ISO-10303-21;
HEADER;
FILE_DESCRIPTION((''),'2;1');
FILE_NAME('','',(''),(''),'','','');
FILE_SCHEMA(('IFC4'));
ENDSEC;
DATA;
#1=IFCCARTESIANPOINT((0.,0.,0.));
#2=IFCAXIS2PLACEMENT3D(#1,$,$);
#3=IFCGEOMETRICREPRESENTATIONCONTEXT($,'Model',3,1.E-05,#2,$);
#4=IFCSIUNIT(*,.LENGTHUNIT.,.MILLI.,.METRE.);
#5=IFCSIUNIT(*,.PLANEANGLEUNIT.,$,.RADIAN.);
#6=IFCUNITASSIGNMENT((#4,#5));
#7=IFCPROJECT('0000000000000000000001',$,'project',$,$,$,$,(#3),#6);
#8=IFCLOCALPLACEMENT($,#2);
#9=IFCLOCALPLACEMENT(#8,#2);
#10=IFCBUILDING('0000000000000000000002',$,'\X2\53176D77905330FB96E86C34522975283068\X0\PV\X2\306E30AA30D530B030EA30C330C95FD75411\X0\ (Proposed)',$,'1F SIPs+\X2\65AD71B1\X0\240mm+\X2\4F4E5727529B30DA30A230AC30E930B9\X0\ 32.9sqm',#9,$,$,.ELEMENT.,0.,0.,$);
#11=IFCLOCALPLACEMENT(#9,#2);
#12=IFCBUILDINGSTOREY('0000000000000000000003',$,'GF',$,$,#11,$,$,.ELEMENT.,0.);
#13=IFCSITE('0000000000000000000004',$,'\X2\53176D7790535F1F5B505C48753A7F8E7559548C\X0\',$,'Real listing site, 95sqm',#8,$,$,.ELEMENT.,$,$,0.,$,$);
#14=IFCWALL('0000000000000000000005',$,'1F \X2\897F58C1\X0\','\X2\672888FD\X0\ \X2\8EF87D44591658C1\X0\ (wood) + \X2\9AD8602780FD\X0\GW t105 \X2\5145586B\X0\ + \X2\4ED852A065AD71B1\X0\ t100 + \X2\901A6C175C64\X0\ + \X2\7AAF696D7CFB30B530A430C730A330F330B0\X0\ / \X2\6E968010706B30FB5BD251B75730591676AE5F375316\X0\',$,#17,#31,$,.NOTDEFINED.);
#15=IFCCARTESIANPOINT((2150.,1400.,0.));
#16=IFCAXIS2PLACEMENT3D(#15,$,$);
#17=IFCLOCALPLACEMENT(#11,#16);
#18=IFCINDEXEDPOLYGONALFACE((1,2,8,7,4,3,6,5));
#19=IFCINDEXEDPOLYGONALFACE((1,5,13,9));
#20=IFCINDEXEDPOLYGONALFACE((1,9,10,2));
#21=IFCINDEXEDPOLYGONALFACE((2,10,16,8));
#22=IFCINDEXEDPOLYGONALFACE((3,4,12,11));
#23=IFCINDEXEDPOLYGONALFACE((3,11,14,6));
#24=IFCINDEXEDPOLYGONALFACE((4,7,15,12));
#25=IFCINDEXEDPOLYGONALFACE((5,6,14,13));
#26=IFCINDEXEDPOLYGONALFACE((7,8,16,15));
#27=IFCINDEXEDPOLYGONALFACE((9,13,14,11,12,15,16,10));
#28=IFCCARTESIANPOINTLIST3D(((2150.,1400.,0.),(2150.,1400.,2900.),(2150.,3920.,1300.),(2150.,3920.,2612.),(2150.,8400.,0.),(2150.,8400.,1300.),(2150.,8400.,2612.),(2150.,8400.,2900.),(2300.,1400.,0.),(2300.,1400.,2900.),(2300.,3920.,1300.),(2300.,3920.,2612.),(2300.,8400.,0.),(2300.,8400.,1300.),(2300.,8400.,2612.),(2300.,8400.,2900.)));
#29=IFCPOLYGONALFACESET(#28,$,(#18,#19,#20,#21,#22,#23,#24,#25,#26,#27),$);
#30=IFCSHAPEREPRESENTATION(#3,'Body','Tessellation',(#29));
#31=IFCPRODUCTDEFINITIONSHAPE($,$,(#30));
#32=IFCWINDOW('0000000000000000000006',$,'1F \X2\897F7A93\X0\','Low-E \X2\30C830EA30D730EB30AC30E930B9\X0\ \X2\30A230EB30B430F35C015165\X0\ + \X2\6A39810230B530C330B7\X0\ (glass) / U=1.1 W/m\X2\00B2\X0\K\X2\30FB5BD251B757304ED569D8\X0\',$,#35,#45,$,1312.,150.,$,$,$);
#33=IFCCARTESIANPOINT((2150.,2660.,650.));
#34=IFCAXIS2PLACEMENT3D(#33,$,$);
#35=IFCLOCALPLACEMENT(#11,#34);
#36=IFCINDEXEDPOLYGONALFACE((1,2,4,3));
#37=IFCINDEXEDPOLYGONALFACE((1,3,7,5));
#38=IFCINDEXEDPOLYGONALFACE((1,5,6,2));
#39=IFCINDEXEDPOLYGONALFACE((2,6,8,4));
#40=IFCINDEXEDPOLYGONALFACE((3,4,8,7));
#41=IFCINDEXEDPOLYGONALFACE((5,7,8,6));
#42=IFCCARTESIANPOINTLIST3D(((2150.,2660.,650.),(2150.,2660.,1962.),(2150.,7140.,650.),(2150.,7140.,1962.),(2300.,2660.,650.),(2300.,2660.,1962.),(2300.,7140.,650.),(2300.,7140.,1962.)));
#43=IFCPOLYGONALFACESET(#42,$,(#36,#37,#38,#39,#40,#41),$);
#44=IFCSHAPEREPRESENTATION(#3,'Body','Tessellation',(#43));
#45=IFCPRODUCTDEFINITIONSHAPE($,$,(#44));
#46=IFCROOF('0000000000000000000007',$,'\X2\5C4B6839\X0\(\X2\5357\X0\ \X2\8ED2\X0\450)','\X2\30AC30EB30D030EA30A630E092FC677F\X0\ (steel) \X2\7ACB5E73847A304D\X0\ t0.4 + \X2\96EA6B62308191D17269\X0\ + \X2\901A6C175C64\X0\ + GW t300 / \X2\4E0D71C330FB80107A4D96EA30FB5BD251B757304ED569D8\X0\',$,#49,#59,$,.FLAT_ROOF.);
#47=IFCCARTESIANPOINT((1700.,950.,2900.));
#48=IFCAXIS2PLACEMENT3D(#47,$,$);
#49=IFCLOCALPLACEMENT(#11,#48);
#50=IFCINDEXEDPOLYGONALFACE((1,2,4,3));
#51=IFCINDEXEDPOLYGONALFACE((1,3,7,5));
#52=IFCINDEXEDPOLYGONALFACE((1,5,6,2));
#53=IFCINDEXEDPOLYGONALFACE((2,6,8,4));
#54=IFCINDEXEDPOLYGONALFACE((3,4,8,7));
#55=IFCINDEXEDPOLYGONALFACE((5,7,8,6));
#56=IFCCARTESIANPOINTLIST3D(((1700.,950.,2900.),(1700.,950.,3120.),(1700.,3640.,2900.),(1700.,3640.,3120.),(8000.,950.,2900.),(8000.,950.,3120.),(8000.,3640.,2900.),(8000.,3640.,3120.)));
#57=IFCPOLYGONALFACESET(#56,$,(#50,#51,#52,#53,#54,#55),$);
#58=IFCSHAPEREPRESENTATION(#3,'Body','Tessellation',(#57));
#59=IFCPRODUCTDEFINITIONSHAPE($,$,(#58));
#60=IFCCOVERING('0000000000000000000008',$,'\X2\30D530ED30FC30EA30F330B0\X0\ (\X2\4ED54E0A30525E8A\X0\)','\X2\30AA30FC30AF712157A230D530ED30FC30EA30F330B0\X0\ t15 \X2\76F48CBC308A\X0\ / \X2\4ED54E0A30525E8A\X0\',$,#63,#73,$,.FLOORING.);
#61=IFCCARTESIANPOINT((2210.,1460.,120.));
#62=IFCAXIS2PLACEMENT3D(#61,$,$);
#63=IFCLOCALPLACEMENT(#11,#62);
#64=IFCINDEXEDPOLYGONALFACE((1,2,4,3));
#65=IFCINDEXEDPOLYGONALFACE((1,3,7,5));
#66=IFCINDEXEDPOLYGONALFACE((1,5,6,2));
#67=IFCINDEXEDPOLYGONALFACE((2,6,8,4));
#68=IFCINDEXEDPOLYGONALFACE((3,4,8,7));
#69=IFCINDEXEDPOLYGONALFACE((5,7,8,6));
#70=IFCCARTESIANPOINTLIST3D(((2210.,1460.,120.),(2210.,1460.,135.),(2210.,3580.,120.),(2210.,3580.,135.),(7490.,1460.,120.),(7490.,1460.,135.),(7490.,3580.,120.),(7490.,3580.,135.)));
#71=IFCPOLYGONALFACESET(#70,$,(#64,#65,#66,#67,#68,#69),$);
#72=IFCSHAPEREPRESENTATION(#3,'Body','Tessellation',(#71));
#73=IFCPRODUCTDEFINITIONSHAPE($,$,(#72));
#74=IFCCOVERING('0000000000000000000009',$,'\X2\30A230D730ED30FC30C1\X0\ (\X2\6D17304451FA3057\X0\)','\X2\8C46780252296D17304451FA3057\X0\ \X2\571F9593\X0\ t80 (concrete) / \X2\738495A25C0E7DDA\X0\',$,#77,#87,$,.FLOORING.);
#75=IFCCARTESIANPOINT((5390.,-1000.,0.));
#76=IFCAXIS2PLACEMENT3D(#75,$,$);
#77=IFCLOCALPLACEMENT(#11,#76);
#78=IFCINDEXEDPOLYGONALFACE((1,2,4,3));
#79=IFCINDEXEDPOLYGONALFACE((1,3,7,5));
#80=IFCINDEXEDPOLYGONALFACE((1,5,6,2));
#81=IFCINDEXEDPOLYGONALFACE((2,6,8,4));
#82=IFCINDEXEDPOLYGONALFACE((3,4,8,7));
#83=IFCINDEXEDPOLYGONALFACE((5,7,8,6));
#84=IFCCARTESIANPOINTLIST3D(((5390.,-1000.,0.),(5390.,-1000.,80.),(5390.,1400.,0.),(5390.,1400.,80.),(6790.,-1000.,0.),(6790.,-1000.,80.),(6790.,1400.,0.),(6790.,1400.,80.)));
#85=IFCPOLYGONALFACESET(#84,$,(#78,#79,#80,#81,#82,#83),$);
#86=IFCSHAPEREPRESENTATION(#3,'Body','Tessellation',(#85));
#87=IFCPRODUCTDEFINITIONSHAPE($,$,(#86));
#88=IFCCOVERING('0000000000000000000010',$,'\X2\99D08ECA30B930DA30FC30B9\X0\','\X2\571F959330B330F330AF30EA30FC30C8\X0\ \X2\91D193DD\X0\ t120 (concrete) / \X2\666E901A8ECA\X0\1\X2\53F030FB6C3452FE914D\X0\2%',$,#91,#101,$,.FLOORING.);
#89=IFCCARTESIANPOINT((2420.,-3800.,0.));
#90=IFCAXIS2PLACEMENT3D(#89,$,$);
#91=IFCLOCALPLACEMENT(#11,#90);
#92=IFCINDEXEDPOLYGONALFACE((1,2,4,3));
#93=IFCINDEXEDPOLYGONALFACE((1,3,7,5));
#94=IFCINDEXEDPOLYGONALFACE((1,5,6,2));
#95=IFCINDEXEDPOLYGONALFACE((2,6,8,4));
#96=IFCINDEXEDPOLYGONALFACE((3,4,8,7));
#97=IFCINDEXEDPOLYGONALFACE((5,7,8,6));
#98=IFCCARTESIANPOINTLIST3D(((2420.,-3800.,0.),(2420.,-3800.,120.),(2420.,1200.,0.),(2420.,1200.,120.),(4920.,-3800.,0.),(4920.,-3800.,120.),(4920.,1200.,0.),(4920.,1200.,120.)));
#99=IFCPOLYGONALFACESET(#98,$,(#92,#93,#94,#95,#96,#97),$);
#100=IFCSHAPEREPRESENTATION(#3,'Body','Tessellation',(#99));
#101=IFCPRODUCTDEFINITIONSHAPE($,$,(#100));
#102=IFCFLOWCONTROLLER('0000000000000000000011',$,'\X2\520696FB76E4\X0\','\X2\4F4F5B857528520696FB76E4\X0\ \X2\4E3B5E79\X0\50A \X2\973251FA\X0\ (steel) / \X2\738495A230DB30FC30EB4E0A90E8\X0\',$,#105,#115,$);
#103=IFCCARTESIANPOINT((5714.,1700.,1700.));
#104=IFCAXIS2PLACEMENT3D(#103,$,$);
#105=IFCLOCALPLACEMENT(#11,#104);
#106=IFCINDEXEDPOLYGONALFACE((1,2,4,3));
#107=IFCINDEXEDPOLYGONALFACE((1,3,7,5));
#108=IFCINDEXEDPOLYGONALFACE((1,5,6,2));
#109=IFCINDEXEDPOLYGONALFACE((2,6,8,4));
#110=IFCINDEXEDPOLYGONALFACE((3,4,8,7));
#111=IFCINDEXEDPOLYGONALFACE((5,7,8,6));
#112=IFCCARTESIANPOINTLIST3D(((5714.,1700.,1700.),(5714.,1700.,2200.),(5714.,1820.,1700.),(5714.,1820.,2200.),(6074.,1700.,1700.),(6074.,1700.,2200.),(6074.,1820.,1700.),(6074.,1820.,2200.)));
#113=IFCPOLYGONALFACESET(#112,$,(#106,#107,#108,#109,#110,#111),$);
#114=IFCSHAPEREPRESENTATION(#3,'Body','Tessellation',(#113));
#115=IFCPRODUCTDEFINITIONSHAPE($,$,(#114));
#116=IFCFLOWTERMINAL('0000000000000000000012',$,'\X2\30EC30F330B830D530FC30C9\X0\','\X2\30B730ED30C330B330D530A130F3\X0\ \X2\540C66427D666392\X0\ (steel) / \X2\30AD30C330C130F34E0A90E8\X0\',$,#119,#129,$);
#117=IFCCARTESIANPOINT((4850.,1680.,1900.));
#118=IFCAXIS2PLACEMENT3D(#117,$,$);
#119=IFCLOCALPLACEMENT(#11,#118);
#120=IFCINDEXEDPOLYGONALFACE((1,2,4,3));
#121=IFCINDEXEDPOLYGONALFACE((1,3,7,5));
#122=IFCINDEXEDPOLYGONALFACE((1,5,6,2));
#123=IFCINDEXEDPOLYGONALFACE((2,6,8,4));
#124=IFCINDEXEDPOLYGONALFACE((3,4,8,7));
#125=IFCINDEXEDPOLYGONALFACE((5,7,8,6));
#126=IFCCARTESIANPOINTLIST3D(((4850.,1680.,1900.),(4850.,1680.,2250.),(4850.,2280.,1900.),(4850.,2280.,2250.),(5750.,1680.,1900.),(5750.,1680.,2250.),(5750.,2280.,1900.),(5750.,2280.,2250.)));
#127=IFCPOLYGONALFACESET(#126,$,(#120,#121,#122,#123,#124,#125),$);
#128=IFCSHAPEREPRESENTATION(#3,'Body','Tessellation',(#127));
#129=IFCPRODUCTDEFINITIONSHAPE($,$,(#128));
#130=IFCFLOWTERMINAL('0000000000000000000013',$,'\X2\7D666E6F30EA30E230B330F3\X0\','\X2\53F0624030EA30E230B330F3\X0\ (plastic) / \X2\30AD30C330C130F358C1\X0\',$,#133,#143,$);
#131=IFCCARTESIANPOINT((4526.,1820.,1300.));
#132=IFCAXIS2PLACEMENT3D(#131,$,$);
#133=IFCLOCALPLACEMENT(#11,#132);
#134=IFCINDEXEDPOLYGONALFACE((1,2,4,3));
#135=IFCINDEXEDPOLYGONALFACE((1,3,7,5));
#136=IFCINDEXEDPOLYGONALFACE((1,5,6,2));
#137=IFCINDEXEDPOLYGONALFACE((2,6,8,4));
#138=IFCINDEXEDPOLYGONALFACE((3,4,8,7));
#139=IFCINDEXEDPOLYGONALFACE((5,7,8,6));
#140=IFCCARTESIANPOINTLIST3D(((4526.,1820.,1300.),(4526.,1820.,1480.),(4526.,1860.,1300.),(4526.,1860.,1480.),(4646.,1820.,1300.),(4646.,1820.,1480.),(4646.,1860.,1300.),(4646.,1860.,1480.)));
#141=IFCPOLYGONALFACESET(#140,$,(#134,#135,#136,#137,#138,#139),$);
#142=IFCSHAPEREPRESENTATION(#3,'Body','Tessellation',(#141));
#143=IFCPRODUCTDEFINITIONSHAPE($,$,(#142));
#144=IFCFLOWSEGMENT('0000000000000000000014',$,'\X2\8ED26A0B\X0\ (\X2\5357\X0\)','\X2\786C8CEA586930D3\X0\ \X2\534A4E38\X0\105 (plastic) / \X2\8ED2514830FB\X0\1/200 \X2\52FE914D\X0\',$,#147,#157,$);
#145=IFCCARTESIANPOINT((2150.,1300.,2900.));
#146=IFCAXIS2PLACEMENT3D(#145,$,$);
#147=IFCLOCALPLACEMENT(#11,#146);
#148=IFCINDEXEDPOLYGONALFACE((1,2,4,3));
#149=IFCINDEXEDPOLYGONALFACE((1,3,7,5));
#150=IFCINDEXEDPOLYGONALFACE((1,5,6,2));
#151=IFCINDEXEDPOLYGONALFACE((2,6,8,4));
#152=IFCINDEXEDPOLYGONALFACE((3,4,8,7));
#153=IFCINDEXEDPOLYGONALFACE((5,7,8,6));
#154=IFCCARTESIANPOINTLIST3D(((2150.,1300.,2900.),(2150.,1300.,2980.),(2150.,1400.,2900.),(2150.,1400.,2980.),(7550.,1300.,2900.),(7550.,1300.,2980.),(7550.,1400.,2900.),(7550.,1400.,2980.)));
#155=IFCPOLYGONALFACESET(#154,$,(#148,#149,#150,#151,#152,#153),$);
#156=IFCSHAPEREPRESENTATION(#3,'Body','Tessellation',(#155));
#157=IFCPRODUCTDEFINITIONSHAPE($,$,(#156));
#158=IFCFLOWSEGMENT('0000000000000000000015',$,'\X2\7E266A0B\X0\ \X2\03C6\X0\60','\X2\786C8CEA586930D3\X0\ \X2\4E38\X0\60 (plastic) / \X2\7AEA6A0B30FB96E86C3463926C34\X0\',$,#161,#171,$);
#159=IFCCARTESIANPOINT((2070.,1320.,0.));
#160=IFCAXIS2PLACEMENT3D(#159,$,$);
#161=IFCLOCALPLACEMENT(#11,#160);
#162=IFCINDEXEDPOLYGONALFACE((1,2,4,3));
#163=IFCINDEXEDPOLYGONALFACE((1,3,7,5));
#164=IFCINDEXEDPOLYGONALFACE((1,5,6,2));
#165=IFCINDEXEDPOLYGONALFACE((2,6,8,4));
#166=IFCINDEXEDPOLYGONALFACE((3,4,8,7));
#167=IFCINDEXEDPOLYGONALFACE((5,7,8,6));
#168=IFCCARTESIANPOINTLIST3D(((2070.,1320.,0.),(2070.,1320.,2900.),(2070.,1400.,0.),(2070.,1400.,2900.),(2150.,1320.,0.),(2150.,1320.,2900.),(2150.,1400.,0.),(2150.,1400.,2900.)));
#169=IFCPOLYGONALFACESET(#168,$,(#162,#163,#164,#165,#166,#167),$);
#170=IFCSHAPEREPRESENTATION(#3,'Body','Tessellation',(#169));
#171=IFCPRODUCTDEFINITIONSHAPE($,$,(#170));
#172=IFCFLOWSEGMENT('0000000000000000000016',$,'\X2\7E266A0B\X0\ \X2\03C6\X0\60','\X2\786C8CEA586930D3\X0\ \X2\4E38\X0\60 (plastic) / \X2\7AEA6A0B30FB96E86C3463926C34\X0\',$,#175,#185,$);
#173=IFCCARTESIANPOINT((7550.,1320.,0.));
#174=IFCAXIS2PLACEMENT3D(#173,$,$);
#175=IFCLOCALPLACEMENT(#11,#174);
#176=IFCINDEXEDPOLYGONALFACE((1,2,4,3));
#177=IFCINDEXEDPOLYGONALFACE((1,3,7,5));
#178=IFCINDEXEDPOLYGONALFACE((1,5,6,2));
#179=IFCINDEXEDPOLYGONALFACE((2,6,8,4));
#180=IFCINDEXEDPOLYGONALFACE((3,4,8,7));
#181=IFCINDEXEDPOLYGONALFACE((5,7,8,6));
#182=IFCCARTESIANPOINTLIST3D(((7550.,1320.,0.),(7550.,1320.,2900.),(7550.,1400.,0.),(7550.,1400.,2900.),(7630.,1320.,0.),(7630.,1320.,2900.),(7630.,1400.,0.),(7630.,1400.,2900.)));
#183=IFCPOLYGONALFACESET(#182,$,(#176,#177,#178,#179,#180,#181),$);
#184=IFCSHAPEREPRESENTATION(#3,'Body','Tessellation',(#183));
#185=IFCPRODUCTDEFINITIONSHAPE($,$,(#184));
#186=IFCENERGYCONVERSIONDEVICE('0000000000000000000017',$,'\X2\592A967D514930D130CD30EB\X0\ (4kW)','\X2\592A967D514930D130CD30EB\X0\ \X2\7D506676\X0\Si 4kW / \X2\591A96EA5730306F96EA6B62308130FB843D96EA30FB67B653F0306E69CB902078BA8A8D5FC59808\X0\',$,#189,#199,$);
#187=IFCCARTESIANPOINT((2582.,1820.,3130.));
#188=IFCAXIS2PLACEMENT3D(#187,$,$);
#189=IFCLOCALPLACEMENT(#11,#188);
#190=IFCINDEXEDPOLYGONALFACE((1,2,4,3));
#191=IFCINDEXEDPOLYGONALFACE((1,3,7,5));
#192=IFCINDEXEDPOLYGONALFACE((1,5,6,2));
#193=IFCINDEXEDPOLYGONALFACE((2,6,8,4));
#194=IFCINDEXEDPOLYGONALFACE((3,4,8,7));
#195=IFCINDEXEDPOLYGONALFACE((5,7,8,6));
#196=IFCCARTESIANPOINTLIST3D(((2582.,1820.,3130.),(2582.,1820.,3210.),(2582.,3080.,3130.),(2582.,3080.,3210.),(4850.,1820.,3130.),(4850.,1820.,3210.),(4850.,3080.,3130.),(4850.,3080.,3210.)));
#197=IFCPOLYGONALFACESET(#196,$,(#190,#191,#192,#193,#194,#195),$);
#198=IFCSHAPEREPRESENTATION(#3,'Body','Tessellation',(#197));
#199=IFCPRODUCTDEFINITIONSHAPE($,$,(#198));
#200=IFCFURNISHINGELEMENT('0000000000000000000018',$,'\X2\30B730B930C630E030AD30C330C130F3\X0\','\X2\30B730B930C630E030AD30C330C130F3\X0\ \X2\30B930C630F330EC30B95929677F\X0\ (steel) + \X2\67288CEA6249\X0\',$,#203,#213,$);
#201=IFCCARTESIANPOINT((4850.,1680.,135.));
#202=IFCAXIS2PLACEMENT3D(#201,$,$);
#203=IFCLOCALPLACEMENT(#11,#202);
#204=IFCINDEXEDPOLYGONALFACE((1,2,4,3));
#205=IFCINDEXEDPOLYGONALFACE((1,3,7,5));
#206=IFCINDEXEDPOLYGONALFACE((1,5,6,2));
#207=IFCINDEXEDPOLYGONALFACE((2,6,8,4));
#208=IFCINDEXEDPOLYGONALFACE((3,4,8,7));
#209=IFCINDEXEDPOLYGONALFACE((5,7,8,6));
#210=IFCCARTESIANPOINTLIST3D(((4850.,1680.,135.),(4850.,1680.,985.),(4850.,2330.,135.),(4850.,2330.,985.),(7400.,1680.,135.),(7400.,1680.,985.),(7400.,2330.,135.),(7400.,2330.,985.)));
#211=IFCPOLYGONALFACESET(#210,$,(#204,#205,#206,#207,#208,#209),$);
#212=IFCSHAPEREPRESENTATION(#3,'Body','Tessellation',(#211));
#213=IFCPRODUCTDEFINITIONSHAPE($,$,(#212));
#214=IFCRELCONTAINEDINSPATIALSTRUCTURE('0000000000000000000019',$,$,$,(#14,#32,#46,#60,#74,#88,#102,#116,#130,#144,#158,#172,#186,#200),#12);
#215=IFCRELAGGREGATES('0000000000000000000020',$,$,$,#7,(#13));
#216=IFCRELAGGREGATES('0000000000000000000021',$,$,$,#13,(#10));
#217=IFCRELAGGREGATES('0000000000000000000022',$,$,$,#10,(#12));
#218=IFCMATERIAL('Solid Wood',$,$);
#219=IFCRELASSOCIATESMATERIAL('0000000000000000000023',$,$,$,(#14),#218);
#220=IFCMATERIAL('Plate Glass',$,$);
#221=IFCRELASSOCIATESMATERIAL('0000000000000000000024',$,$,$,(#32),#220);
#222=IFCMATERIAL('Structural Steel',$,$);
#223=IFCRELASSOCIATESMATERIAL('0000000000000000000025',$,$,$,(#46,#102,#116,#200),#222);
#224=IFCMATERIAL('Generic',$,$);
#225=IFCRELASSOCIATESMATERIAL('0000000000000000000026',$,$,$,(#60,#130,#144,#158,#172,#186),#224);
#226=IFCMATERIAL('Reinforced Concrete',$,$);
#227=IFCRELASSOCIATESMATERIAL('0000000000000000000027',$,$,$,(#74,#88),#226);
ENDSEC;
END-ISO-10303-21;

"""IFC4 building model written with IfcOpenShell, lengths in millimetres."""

from ifc_helpers import new_model, si_unit, frame, frame_2d, origin, place, context, project, spatial, rectangle, extrude, material, element, fill, save


model = new_model("IFC4")

# Units and contexts
model_context = context("Model", 3, precision=1e-05, world=origin())
ifc_project = project(units=[si_unit("LENGTHUNIT", "METRE", prefix="MILLI"), si_unit("PLANEANGLEUNIT", "RADIAN")], contexts=[model_context])

# Site, building, storey
site_placement = place(None, origin())
site = spatial("IfcSite", under=ifc_project, at=site_placement, Name="北海道弟子屈町美留和", ObjectType="Real listing site, 95sqm", CompositionType="ELEMENT", RefElevation=0.0)
building_placement = place(site_placement, origin())
building = spatial("IfcBuilding", under=site, at=building_placement, Name="北海道・雨水利用とPVのオフグリッド志向 (Proposed)", ObjectType="1F SIPs+断熱240mm+低圧力ペアガラス 32.9sqm", CompositionType="ELEMENT", ElevationOfRefHeight=0.0, ElevationOfTerrain=0.0)
storey_placement = place(building_placement, origin())
storey = spatial("IfcBuildingStorey", under=building, at=storey_placement, Name="GF", CompositionType="ELEMENT", Elevation=0.0)

# Shared definitions
ifc_material_1 = material(Name="Solid Wood")

# Shared definitions
ifc_material_2 = material(Name="Reinforced Concrete")

# Shared definitions
ifc_material_3 = material(Name="Plate Glass")

# Wall, opening, window
wall_1_placement = place(storey_placement, frame((2150.0, 1400.0, 0.0)))
wall_1 = element("IfcWall", 1, at=wall_1_placement, inside=storey, material=ifc_material_1, Name="1F 西壁", Description="木製 軸組外壁 (wood) + 高性能GW t105 充填 + 付加断熱 t100 + 通気層 + 窯業系サイディング / 準耐火・寒冷地外皮強化", PredefinedType="NOTDEFINED", context=model_context, shape_type="SweptSolid", body=[
    extrude(rectangle(XDim=150.0, YDim=7000.0, at=frame_2d((75.0, 3500.0))), frame((2150.0, 1400.0, 0.0)), (0.0, 0.0, 1.0), 2900.0),
])
opening_1_placement = place(storey_placement, frame((2150.0, 2660.0, 650.0)))
opening_1 = element("IfcOpeningElement", 2, at=opening_1_placement, cuts=wall_1, PredefinedType="NOTDEFINED", context=model_context, shape_type="SweptSolid", body=[
    extrude(rectangle(XDim=150.0, YDim=4480.0, at=frame_2d((75.0, 2240.0))), frame((2150.0, 2660.0, 650.0)), (0.0, 0.0, 1.0), 1312.0),
])
window_1_placement = place(storey_placement, frame((2150.0, 2660.0, 650.0)))
window_1 = element("IfcWindow", 3, at=window_1_placement, inside=storey, material=ifc_material_3, Name="1F 西窓", Description="Low-E トリプルガラス アルゴン封入 + 樹脂サッシ (glass) / U=1.1 W/m²K・寒冷地仕様", OverallHeight=1312.0, OverallWidth=150.0, context=model_context, shape_type="SweptSolid", body=[
    extrude(rectangle(XDim=150.0, YDim=4480.0, at=frame_2d((75.0, 2240.0))), frame((2150.0, 2660.0, 650.0)), (0.0, 0.0, 1.0), 1312.0),
])
fill(opening_1, window_1)

# Roof
ifc_material_4 = material(Name="Structural Steel")
roof_placement = place(storey_placement, frame((1700.0, 950.0, 2900.0)))
element("IfcRoof", 4, at=roof_placement, inside=storey, material=ifc_material_4, Name="屋根(南 軒450)", Description="ガルバリウム鋼板 (steel) 立平葺き t0.4 + 雪止め金物 + 通気層 + GW t300 / 不燃・耐積雪・寒冷地仕様", PredefinedType="FLAT_ROOF", context=model_context, shape_type="SweptSolid", body=[
    extrude(rectangle(XDim=6300.0, YDim=2690.0, at=frame_2d((3150.0, 1345.0))), frame((1700.0, 950.0, 2900.0)), (0.0, 0.0, 1.0), 220.0),
])

# Coverings
ifc_material_5 = material(Name="Generic")
covering_1_placement = place(storey_placement, frame((2210.0, 1460.0, 120.0)))
element("IfcCovering", 5, at=covering_1_placement, inside=storey, material=ifc_material_5, Name="フローリング (仕上げ床)", Description="オーク無垢フローリング t15 直貼り / 仕上げ床", PredefinedType="FLOORING", context=model_context, shape_type="SweptSolid", body=[
    extrude(rectangle(XDim=5280.0, YDim=2120.0, at=frame_2d((2640.0, 1060.0))), frame((2210.0, 1460.0, 120.0)), (0.0, 0.0, 1.0), 15.0),
])
covering_2_placement = place(storey_placement, frame((5390.0, -1000.0, 0.0)))
element("IfcCovering", 6, at=covering_2_placement, inside=storey, material=ifc_material_2, Name="アプローチ (洗い出し)", Description="豆砂利洗い出し 土間 t80 (concrete) / 玄関導線", PredefinedType="FLOORING", context=model_context, shape_type="SweptSolid", body=[
    extrude(rectangle(XDim=1400.0, YDim=2400.0, at=frame_2d((700.0, 1200.0))), frame((5390.0, -1000.0, 0.0)), (0.0, 0.0, 1.0), 80.0),
])
covering_3_placement = place(storey_placement, frame((2420.0, -3800.0, 0.0)))
element("IfcCovering", 7, at=covering_3_placement, inside=storey, material=ifc_material_2, Name="駐車スペース", Description="土間コンクリート 金鏝 t120 (concrete) / 普通車1台・水勾配2%", PredefinedType="FLOORING", context=model_context, shape_type="SweptSolid", body=[
    extrude(rectangle(XDim=2500.0, YDim=5000.0, at=frame_2d((1250.0, 2500.0))), frame((2420.0, -3800.0, 0.0)), (0.0, 0.0, 1.0), 120.0),
])

# Flow controller
flow_controller_placement = place(storey_placement, frame((5714.0, 1700.0, 1700.0)))
element("IfcFlowController", 8, at=flow_controller_placement, inside=storey, material=ifc_material_4, Name="分電盤", Description="住宅用分電盤 主幹50A 露出 (steel) / 玄関ホール上部", context=model_context, shape_type="SweptSolid", body=[
    extrude(rectangle(XDim=360.0, YDim=120.0, at=frame_2d((180.0, 60.0))), frame((5714.0, 1700.0, 1700.0)), (0.0, 0.0, 1.0), 500.0),
])

# Flow terminals
flow_terminal_1_placement = place(storey_placement, frame((4850.0, 1680.0, 1900.0)))
element("IfcFlowTerminal", 9, at=flow_terminal_1_placement, inside=storey, material=ifc_material_4, Name="レンジフード", Description="シロッコファン 同時給排 (steel) / キッチン上部", context=model_context, shape_type="SweptSolid", body=[
    extrude(rectangle(XDim=900.0, YDim=600.0, at=frame_2d((450.0, 300.0))), frame((4850.0, 1680.0, 1900.0)), (0.0, 0.0, 1.0), 350.0),
])
flow_terminal_2_placement = place(storey_placement, frame((4526.0, 1820.0, 1300.0)))
element("IfcFlowTerminal", 10, at=flow_terminal_2_placement, inside=storey, material=ifc_material_5, Name="給湯リモコン", Description="台所リモコン (plastic) / キッチン壁", context=model_context, shape_type="SweptSolid", body=[
    extrude(rectangle(XDim=120.0, YDim=40.0, at=frame_2d((60.0, 20.0))), frame((4526.0, 1820.0, 1300.0)), (0.0, 0.0, 1.0), 180.0),
])

# Flow segments
flow_segment_1_placement = place(storey_placement, frame((2150.0, 1300.0, 2900.0)))
element("IfcFlowSegment", 11, at=flow_segment_1_placement, inside=storey, material=ifc_material_5, Name="軒樋 (南)", Description="硬質塩ビ 半丸105 (plastic) / 軒先・1/200 勾配", context=model_context, shape_type="SweptSolid", body=[
    extrude(rectangle(XDim=5400.0, YDim=100.0, at=frame_2d((2700.0, 50.0))), frame((2150.0, 1300.0, 2900.0)), (0.0, 0.0, 1.0), 80.0),
])
flow_segment_2_placement = place(storey_placement, frame((2070.0, 1320.0, 0.0)))
element("IfcFlowSegment", 12, at=flow_segment_2_placement, inside=storey, material=ifc_material_5, Name="縦樋 φ60", Description="硬質塩ビ 丸60 (plastic) / 竪樋・雨水排水", context=model_context, shape_type="SweptSolid", body=[
    extrude(rectangle(XDim=80.0, YDim=80.0, at=frame_2d((40.0, 40.0))), frame((2070.0, 1320.0, 0.0)), (0.0, 0.0, 1.0), 2900.0),
])
flow_segment_3_placement = place(storey_placement, frame((7550.0, 1320.0, 0.0)))
element("IfcFlowSegment", 13, at=flow_segment_3_placement, inside=storey, material=ifc_material_5, Name="縦樋 φ60", Description="硬質塩ビ 丸60 (plastic) / 竪樋・雨水排水", context=model_context, shape_type="SweptSolid", body=[
    extrude(rectangle(XDim=80.0, YDim=80.0, at=frame_2d((40.0, 40.0))), frame((7550.0, 1320.0, 0.0)), (0.0, 0.0, 1.0), 2900.0),
])

# Energy conversion device
energy_conversion_device_placement = place(storey_placement, frame((2582.0, 1820.0, 3130.0)))
element("IfcEnergyConversionDevice", 14, at=energy_conversion_device_placement, inside=storey, material=ifc_material_5, Name="太陽光パネル (4kW)", Description="太陽光パネル 結晶Si 4kW / 多雪地は雪止め・落雪・架台の構造確認必須", context=model_context, shape_type="SweptSolid", body=[
    extrude(rectangle(XDim=2268.0, YDim=1260.0, at=frame_2d((1134.0, 630.0))), frame((2582.0, 1820.0, 3130.0)), (0.0, 0.0, 1.0), 80.0),
])

# Furnishing element
furnishing_placement = place(storey_placement, frame((4850.0, 1680.0, 135.0)))
element("IfcFurnishingElement", 15, at=furnishing_placement, inside=storey, material=ifc_material_4, Name="システムキッチン", Description="システムキッチン ステンレス天板 (steel) + 木質扉", context=model_context, shape_type="SweptSolid", body=[
    extrude(rectangle(XDim=2550.0, YDim=650.0, at=frame_2d((1275.0, 325.0))), frame((4850.0, 1680.0, 135.0)), (0.0, 0.0, 1.0), 850.0),
])

save(model, "model.ifc")
